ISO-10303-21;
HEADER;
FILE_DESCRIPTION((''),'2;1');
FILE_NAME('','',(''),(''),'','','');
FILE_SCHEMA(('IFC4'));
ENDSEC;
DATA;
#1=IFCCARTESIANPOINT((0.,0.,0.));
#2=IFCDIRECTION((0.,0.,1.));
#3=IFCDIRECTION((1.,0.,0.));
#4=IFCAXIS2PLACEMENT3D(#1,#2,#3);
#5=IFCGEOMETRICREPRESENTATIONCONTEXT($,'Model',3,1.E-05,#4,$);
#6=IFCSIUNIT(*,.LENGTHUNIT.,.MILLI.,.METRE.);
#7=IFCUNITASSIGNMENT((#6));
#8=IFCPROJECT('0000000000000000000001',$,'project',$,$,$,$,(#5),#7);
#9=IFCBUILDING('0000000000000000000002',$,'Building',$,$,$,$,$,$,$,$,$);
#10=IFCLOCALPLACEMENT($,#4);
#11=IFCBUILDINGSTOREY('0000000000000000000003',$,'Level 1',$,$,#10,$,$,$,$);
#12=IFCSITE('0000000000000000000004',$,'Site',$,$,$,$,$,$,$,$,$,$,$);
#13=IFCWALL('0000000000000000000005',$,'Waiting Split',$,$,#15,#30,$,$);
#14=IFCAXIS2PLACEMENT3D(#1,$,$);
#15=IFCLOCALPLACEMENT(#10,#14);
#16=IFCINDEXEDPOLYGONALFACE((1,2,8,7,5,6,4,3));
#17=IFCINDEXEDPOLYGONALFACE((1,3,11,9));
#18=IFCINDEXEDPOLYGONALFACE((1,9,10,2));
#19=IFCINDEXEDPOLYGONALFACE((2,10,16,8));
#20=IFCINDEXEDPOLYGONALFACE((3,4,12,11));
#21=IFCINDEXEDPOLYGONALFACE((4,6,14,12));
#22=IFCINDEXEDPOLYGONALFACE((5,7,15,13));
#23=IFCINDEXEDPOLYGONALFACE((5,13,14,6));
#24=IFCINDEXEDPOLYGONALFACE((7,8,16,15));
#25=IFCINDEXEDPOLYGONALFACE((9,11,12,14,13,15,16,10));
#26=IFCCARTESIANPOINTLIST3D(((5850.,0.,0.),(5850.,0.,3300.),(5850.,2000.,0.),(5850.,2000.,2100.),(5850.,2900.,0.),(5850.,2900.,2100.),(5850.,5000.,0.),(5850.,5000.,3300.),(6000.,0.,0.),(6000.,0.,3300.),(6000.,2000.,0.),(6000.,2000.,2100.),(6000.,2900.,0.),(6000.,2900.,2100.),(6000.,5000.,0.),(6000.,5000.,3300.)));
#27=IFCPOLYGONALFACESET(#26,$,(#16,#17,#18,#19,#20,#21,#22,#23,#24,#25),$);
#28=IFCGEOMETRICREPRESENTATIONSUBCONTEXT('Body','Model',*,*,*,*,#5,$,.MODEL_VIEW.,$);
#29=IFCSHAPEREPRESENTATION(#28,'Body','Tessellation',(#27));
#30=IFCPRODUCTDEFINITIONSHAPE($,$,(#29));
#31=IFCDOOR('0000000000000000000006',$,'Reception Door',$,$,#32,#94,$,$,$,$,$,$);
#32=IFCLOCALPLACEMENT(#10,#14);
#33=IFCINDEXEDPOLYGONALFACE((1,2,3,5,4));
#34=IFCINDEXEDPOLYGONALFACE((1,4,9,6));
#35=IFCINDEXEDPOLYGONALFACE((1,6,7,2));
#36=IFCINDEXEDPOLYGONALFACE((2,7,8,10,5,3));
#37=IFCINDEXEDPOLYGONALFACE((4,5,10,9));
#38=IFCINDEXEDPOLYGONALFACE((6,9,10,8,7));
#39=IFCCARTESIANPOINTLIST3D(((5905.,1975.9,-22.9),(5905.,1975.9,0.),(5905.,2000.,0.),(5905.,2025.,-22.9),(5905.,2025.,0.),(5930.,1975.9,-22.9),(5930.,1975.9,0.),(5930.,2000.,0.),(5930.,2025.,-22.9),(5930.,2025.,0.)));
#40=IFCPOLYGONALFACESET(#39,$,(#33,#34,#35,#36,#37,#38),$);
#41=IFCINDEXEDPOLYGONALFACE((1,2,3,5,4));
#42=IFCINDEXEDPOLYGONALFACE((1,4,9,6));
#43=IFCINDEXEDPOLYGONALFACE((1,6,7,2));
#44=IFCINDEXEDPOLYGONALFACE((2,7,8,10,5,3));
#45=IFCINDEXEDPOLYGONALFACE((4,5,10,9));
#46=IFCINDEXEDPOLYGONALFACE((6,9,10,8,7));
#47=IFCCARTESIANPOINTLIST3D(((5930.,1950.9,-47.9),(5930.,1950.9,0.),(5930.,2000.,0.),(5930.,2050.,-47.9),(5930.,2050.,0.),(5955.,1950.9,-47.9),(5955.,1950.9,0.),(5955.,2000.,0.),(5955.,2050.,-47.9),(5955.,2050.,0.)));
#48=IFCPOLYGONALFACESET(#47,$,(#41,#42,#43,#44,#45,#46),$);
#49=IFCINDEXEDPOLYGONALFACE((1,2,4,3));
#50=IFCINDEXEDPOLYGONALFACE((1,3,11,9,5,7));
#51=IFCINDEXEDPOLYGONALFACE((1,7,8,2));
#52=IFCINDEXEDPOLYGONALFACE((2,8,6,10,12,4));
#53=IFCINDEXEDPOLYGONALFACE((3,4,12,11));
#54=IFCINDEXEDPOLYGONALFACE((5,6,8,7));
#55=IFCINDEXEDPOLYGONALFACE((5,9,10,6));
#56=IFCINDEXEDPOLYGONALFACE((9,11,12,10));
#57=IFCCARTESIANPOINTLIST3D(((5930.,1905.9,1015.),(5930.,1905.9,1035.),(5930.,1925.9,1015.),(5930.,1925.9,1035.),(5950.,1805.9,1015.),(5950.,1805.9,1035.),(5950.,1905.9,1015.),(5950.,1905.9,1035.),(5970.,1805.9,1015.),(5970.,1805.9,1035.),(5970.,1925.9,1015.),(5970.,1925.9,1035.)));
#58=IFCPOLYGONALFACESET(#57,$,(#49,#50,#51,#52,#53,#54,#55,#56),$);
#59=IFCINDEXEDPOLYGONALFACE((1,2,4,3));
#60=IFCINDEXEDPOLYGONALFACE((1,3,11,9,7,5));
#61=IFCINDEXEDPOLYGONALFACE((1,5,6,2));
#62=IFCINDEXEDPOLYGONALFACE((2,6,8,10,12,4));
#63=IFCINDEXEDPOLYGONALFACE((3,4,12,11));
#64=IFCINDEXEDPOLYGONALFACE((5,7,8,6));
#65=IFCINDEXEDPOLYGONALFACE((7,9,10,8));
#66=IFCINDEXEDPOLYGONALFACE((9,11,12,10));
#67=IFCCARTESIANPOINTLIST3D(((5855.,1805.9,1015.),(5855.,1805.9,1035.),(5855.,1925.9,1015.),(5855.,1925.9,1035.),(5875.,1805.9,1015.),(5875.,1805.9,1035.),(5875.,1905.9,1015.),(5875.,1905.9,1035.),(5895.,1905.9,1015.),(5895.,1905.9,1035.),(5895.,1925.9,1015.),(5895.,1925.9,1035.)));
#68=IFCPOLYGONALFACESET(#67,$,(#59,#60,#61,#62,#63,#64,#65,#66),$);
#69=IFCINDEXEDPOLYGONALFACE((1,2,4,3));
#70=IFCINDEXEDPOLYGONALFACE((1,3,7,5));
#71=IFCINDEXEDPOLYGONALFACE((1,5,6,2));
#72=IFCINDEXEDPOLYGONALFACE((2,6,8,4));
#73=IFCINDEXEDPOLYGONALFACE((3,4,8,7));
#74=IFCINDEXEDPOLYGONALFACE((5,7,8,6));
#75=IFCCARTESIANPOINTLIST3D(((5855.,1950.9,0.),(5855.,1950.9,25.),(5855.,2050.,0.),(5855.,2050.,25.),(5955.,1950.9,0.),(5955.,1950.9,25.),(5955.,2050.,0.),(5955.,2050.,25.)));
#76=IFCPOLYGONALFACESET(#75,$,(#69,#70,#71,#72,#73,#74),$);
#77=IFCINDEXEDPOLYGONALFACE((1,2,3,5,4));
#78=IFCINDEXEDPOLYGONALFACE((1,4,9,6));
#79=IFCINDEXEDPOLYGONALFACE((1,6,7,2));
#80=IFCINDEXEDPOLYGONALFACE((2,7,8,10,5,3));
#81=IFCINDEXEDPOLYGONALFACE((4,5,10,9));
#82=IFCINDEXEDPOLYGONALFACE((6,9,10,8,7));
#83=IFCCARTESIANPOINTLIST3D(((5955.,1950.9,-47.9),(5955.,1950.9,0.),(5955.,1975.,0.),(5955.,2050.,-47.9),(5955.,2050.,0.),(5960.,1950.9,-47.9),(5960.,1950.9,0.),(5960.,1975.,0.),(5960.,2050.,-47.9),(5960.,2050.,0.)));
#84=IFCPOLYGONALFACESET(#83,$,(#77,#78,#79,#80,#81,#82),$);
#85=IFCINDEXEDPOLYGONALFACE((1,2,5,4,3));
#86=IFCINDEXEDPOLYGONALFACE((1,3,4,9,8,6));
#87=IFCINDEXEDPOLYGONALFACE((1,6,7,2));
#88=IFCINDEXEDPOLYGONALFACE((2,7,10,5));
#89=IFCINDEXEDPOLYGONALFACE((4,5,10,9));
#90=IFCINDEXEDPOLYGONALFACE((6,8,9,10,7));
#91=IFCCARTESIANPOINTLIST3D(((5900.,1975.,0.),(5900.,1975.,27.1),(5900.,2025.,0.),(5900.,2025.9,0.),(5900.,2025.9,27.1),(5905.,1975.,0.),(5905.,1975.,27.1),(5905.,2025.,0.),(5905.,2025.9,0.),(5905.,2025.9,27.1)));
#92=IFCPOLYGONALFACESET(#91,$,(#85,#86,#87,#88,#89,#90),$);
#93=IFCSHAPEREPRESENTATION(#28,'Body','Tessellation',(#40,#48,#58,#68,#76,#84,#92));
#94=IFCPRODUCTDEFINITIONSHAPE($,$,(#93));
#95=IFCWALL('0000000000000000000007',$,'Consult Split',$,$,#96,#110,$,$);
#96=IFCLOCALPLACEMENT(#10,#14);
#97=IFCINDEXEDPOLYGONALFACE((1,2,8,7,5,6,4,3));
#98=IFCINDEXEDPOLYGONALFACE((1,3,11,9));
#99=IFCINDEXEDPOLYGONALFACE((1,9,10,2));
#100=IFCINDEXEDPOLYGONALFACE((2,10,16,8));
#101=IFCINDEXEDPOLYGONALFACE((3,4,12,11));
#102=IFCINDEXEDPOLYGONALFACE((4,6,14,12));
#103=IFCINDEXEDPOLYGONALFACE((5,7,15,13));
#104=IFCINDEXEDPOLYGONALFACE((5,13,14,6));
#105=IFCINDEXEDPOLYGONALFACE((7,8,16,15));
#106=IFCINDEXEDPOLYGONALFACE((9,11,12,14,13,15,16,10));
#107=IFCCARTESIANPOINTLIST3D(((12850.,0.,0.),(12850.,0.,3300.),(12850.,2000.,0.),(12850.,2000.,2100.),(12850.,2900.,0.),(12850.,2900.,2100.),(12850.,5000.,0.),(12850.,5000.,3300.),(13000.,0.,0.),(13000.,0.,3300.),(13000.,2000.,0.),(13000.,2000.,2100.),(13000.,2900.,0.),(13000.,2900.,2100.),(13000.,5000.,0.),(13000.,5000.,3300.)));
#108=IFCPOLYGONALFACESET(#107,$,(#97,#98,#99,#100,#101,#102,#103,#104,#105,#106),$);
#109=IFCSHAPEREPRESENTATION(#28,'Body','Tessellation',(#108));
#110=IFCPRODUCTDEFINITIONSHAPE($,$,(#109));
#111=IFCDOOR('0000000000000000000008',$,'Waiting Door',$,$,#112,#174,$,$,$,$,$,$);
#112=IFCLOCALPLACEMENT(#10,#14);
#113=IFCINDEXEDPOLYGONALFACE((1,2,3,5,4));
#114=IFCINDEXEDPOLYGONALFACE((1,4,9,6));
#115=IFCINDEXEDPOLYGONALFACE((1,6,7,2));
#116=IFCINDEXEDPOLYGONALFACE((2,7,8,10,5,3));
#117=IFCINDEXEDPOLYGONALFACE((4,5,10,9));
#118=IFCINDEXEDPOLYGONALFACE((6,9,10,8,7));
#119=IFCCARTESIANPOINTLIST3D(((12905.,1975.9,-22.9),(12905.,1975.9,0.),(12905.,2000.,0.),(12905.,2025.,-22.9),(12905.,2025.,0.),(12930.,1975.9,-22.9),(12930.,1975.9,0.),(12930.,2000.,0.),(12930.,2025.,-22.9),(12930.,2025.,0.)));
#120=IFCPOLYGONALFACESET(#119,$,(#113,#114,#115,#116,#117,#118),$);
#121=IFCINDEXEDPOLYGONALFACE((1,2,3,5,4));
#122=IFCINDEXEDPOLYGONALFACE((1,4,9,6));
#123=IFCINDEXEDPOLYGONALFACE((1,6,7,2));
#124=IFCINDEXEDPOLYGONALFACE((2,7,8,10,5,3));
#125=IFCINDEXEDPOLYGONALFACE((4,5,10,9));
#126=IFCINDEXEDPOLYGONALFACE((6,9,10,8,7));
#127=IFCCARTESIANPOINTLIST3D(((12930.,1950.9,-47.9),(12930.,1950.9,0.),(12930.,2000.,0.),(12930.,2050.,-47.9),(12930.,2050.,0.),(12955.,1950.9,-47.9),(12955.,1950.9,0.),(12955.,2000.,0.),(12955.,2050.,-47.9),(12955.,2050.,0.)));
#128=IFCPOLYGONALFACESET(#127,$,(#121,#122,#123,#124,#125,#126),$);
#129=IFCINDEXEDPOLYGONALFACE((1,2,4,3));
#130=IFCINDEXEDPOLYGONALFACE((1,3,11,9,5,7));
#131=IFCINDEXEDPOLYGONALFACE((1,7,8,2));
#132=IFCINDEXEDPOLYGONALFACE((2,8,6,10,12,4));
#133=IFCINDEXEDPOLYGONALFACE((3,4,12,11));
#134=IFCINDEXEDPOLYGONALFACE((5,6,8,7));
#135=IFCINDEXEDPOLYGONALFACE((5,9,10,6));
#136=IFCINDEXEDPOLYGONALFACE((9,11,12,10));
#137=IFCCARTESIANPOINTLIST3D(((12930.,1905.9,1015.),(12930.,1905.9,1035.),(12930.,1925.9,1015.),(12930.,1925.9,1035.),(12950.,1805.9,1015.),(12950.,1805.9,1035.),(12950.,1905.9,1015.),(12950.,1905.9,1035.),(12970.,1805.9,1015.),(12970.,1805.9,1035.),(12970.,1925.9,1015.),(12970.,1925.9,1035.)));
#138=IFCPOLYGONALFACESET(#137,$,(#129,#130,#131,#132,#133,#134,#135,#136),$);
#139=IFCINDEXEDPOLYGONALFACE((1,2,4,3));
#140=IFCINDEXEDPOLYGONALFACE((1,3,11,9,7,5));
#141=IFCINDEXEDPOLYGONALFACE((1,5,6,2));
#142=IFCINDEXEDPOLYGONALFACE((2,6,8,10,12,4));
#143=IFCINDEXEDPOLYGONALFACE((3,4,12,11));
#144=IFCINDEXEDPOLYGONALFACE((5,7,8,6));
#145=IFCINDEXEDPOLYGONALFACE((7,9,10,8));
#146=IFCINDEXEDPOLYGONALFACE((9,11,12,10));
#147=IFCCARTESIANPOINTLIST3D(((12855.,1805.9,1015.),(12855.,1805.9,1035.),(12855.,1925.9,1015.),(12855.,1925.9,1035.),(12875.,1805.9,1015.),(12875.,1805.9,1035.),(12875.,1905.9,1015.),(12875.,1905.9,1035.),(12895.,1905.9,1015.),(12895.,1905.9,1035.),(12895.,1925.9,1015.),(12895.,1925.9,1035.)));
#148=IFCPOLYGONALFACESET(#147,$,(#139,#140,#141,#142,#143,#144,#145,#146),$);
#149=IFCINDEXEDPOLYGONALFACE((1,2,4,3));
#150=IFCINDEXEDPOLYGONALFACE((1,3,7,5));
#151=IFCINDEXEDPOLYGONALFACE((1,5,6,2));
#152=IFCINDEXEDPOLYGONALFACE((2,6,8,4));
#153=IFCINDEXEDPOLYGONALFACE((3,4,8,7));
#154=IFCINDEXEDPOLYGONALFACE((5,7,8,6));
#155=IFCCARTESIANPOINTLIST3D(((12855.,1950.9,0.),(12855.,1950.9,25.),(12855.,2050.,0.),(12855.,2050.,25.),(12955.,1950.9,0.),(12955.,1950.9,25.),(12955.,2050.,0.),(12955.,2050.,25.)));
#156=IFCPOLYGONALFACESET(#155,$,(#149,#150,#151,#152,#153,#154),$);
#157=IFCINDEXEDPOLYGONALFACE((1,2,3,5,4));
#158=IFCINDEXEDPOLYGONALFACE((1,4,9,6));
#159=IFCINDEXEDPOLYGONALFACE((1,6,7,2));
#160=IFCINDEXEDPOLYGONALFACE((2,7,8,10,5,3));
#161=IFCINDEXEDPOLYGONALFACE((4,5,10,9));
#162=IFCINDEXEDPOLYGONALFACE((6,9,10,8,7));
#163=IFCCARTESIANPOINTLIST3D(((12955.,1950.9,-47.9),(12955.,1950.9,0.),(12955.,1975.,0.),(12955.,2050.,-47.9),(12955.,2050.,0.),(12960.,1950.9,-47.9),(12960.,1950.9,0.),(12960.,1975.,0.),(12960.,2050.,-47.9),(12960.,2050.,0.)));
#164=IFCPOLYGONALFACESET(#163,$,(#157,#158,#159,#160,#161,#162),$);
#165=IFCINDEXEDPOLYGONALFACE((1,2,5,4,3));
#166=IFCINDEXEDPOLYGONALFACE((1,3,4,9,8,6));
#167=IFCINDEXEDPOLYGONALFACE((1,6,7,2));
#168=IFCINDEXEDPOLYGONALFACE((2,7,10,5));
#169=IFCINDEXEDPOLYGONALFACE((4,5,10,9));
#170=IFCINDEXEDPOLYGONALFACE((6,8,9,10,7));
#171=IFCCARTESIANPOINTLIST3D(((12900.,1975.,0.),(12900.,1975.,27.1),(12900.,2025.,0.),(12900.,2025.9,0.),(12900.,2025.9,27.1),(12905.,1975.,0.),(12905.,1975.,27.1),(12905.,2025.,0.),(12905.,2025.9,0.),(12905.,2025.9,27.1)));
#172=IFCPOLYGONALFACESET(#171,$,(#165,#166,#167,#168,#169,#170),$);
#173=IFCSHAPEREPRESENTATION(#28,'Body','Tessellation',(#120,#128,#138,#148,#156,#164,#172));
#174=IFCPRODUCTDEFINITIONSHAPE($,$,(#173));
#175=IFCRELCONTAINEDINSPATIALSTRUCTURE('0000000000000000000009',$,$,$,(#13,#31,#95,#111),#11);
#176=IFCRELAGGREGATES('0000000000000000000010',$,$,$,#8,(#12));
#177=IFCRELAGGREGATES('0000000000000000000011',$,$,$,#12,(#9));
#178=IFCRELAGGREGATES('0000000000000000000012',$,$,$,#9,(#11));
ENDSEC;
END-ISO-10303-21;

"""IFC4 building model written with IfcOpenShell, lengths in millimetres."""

from ifc_helpers import new_model, si_unit, frame, origin_with_axes, place, context, subcontext, project, spatial, line, indexed_curve, outline, extrude, element, fill, save


model = new_model("IFC4")

# Units and contexts
model_context = context("Model", 3, precision=1e-05, world=origin_with_axes())
body_context = subcontext(model_context, "Body", "Model", "MODEL_VIEW")
ifc_project = project(units=[si_unit("LENGTHUNIT", "METRE", prefix="MILLI")], contexts=[model_context])

# Site, building, storey
site = spatial("IfcSite", under=ifc_project, Name="Site")
building = spatial("IfcBuilding", under=site, Name="Building")
storey_placement = place(None, origin_with_axes())
storey = spatial("IfcBuildingStorey", under=building, at=storey_placement, Name="Level 1")

# Walls, openings, doors
wall_1_placement = place(storey_placement, frame((6000.0, 0.0, 0.0), z_axis=(0.0, 0.0, 1.0), x_axis=(0.0, 1.0, 0.0)))
wall_1 = element("IfcWall", 1, at=wall_1_placement, inside=storey, Name="Waiting Split", context=body_context, shape_type="SweptSolid", body=[
    extrude(outline(indexed_curve([(0.0, 0.0), (0.0, 150.0), (5000.0, 150.0), (5000.0, 0.0), (0.0, 0.0)], self_intersect=False)), origin_with_axes(), (0.0, 0.0, 1.0), 3300.0),
])
opening_1_placement = place(wall_1_placement, frame((2000.0, -100.0, 0.0), z_axis=(0.0, 0.0, 1.0), x_axis=(1.0, 0.0, 0.0)))
opening_1 = element("IfcOpeningElement", 2, at=opening_1_placement, cuts=wall_1, context=body_context, shape_type="SweptSolid", body=[
    extrude(outline(indexed_curve([(0.0, 0.0), (0.0, 350.0), (900.0, 350.0), (900.0, 0.0), (0.0, 0.0)], self_intersect=False)), origin_with_axes(), (0.0, 0.0, 1.0), 2100.0),
])
door_1_placement = place(opening_1_placement, frame((0.0, 145.0, 0.0), z_axis=(0.0, 0.0, 1.0), x_axis=(1.0, 0.0, 0.0)))
door_1 = element("IfcDoor", 3, at=door_1_placement, inside=storey, Name="Reception Door", context=body_context, shape_type="SweptSolid", body=[
    extrude(outline(indexed_curve([(0.0, 0.0), (0.0, 2.1), (0.9, 2.1), (0.9, 0.0), (-24.1, 0.0), (-24.1, -22.9), (25.0, -22.9), (25.0, 0.0)], segments=[line(1, 2, 3, 4, 5, 6, 7, 8, 1)])), frame((0.0, 25.0, 0.0), z_axis=(0.0, -1.0, 0.0), x_axis=(1.0, 0.0, 0.0)), (0.0, 0.0, -1.0), 25.0),
    extrude(outline(indexed_curve([(0.0, 0.0), (0.0, 2.1), (0.9, 2.1), (0.9, 0.0), (-49.1, 0.0), (-49.1, -47.9), (50.0, -47.9), (50.0, 0.0)], segments=[line(1, 2, 3, 4, 5, 6, 7, 8, 1)])), frame((0.0, 0.0, 0.0), z_axis=(0.0, -1.0, 0.0), x_axis=(1.0, 0.0, 0.0)), (0.0, 0.0, -1.0), 25.0),
    extrude(outline(indexed_curve([(0.0, 0.0), (-49.1, 0.0), (-49.1, 35.0), (0.0, 35.0)], segments=[line(1, 2, 3, 4, 1)])), frame((25.0, 25.0, 25.0), z_axis=(0.0, 0.0, 1.0), x_axis=(1.0, 0.0, 0.0)), (0.0, 0.0, 1.0), -47.9),
    extrude(outline(indexed_curve([(0.0, 0.0), (0.0, -40.0), (-120.0, -40.0), (-120.0, -20.0), (-20.0, -20.0), (-20.0, 0.0)], segments=[line(1, 2, 3, 4, 5, 6, 1)])), frame((-74.1, 25.0, 1015.0), z_axis=(0.0, 0.0, 1.0), x_axis=(1.0, 0.0, 0.0)), (0.0, 0.0, 1.0), 20.0),
    extrude(outline(indexed_curve([(0.0, 0.0), (0.0, 40.0), (-120.0, 40.0), (-120.0, 20.0), (-20.0, 20.0), (-20.0, 0.0)], segments=[line(1, 2, 3, 4, 5, 6, 1)])), frame((-74.1, 60.0, 1015.0), z_axis=(0.0, 0.0, 1.0), x_axis=(1.0, 0.0, 0.0)), (0.0, 0.0, 1.0), 20.0),
    extrude(outline(indexed_curve([(0.0, 0.0), (-99.1, 0.0), (-99.1, 100.0), (0.0, 100.0)], segments=[line(1, 2, 3, 4, 1)])), frame((50.0, 0.0, 0.0), z_axis=(0.0, 0.0, 1.0), x_axis=(1.0, 0.0, 0.0)), (0.0, 0.0, 1.0), 25.0),
    extrude(outline(indexed_curve([(0.0, 0.0), (0.0, 27.1), (50.9, 27.1), (50.9, 0.0), (-24.1, 0.0), (-24.1, -47.9), (75.0, -47.9), (75.0, 0.0)], segments=[line(1, 2, 3, 4, 5, 6, 7, 8, 1)])), frame((-25.0, -5.0, 0.0), z_axis=(0.0, -1.0, 0.0), x_axis=(1.0, 0.0, 0.0)), (0.0, 0.0, -1.0), 5.0),
    extrude(outline(indexed_curve([(0.0, 0.0), (0.0, 27.1), (50.9, 27.1), (50.9, 0.0), (0.9, 0.0), (0.9, -22.9), (50.0, -22.9), (50.0, 0.0)], segments=[line(1, 2, 3, 4, 5, 6, 7, 8, 1)])), frame((-25.0, 50.0, 0.0), z_axis=(0.0, -1.0, 0.0), x_axis=(1.0, 0.0, 0.0)), (0.0, 0.0, -1.0), 5.0),
])
fill(opening_1, door_1)
wall_2_placement = place(storey_placement, frame((13000.0, 0.0, 0.0), z_axis=(0.0, 0.0, 1.0), x_axis=(0.0, 1.0, 0.0)))
wall_2 = element("IfcWall", 4, at=wall_2_placement, inside=storey, Name="Consult Split", context=body_context, shape_type="SweptSolid", body=[
    extrude(outline(indexed_curve([(0.0, 0.0), (0.0, 150.0), (5000.0, 150.0), (5000.0, 0.0), (0.0, 0.0)], self_intersect=False)), origin_with_axes(), (0.0, 0.0, 1.0), 3300.0),
])
opening_2_placement = place(wall_2_placement, frame((2000.0, -100.0, 0.0), z_axis=(0.0, 0.0, 1.0), x_axis=(1.0, 0.0, 0.0)))
opening_2 = element("IfcOpeningElement", 5, at=opening_2_placement, cuts=wall_2, context=body_context, shape_type="SweptSolid", body=[
    extrude(outline(indexed_curve([(0.0, 0.0), (0.0, 350.0), (900.0, 350.0), (900.0, 0.0), (0.0, 0.0)], self_intersect=False)), origin_with_axes(), (0.0, 0.0, 1.0), 2100.0),
])
door_2_placement = place(opening_2_placement, frame((0.0, 145.0, 0.0), z_axis=(0.0, 0.0, 1.0), x_axis=(1.0, 0.0, 0.0)))
door_2 = element("IfcDoor", 6, at=door_2_placement, inside=storey, Name="Waiting Door", context=body_context, shape_type="SweptSolid", body=[
    extrude(outline(indexed_curve([(0.0, 0.0), (0.0, 2.1), (0.9, 2.1), (0.9, 0.0), (-24.1, 0.0), (-24.1, -22.9), (25.0, -22.9), (25.0, 0.0)], segments=[line(1, 2, 3, 4, 5, 6, 7, 8, 1)])), frame((0.0, 25.0, 0.0), z_axis=(0.0, -1.0, 0.0), x_axis=(1.0, 0.0, 0.0)), (0.0, 0.0, -1.0), 25.0),
    extrude(outline(indexed_curve([(0.0, 0.0), (0.0, 2.1), (0.9, 2.1), (0.9, 0.0), (-49.1, 0.0), (-49.1, -47.9), (50.0, -47.9), (50.0, 0.0)], segments=[line(1, 2, 3, 4, 5, 6, 7, 8, 1)])), frame((0.0, 0.0, 0.0), z_axis=(0.0, -1.0, 0.0), x_axis=(1.0, 0.0, 0.0)), (0.0, 0.0, -1.0), 25.0),
    extrude(outline(indexed_curve([(0.0, 0.0), (-49.1, 0.0), (-49.1, 35.0), (0.0, 35.0)], segments=[line(1, 2, 3, 4, 1)])), frame((25.0, 25.0, 25.0), z_axis=(0.0, 0.0, 1.0), x_axis=(1.0, 0.0, 0.0)), (0.0, 0.0, 1.0), -47.9),
    extrude(outline(indexed_curve([(0.0, 0.0), (0.0, -40.0), (-120.0, -40.0), (-120.0, -20.0), (-20.0, -20.0), (-20.0, 0.0)], segments=[line(1, 2, 3, 4, 5, 6, 1)])), frame((-74.1, 25.0, 1015.0), z_axis=(0.0, 0.0, 1.0), x_axis=(1.0, 0.0, 0.0)), (0.0, 0.0, 1.0), 20.0),
    extrude(outline(indexed_curve([(0.0, 0.0), (0.0, 40.0), (-120.0, 40.0), (-120.0, 20.0), (-20.0, 20.0), (-20.0, 0.0)], segments=[line(1, 2, 3, 4, 5, 6, 1)])), frame((-74.1, 60.0, 1015.0), z_axis=(0.0, 0.0, 1.0), x_axis=(1.0, 0.0, 0.0)), (0.0, 0.0, 1.0), 20.0),
    extrude(outline(indexed_curve([(0.0, 0.0), (-99.1, 0.0), (-99.1, 100.0), (0.0, 100.0)], segments=[line(1, 2, 3, 4, 1)])), frame((50.0, 0.0, 0.0), z_axis=(0.0, 0.0, 1.0), x_axis=(1.0, 0.0, 0.0)), (0.0, 0.0, 1.0), 25.0),
    extrude(outline(indexed_curve([(0.0, 0.0), (0.0, 27.1), (50.9, 27.1), (50.9, 0.0), (-24.1, 0.0), (-24.1, -47.9), (75.0, -47.9), (75.0, 0.0)], segments=[line(1, 2, 3, 4, 5, 6, 7, 8, 1)])), frame((-25.0, -5.0, 0.0), z_axis=(0.0, -1.0, 0.0), x_axis=(1.0, 0.0, 0.0)), (0.0, 0.0, -1.0), 5.0),
    extrude(outline(indexed_curve([(0.0, 0.0), (0.0, 27.1), (50.9, 27.1), (50.9, 0.0), (0.9, 0.0), (0.9, -22.9), (50.0, -22.9), (50.0, 0.0)], segments=[line(1, 2, 3, 4, 5, 6, 7, 8, 1)])), frame((-25.0, 50.0, 0.0), z_axis=(0.0, -1.0, 0.0), x_axis=(1.0, 0.0, 0.0)), (0.0, 0.0, -1.0), 5.0),
])
fill(opening_2, door_2)

save(model, "model.ifc")
